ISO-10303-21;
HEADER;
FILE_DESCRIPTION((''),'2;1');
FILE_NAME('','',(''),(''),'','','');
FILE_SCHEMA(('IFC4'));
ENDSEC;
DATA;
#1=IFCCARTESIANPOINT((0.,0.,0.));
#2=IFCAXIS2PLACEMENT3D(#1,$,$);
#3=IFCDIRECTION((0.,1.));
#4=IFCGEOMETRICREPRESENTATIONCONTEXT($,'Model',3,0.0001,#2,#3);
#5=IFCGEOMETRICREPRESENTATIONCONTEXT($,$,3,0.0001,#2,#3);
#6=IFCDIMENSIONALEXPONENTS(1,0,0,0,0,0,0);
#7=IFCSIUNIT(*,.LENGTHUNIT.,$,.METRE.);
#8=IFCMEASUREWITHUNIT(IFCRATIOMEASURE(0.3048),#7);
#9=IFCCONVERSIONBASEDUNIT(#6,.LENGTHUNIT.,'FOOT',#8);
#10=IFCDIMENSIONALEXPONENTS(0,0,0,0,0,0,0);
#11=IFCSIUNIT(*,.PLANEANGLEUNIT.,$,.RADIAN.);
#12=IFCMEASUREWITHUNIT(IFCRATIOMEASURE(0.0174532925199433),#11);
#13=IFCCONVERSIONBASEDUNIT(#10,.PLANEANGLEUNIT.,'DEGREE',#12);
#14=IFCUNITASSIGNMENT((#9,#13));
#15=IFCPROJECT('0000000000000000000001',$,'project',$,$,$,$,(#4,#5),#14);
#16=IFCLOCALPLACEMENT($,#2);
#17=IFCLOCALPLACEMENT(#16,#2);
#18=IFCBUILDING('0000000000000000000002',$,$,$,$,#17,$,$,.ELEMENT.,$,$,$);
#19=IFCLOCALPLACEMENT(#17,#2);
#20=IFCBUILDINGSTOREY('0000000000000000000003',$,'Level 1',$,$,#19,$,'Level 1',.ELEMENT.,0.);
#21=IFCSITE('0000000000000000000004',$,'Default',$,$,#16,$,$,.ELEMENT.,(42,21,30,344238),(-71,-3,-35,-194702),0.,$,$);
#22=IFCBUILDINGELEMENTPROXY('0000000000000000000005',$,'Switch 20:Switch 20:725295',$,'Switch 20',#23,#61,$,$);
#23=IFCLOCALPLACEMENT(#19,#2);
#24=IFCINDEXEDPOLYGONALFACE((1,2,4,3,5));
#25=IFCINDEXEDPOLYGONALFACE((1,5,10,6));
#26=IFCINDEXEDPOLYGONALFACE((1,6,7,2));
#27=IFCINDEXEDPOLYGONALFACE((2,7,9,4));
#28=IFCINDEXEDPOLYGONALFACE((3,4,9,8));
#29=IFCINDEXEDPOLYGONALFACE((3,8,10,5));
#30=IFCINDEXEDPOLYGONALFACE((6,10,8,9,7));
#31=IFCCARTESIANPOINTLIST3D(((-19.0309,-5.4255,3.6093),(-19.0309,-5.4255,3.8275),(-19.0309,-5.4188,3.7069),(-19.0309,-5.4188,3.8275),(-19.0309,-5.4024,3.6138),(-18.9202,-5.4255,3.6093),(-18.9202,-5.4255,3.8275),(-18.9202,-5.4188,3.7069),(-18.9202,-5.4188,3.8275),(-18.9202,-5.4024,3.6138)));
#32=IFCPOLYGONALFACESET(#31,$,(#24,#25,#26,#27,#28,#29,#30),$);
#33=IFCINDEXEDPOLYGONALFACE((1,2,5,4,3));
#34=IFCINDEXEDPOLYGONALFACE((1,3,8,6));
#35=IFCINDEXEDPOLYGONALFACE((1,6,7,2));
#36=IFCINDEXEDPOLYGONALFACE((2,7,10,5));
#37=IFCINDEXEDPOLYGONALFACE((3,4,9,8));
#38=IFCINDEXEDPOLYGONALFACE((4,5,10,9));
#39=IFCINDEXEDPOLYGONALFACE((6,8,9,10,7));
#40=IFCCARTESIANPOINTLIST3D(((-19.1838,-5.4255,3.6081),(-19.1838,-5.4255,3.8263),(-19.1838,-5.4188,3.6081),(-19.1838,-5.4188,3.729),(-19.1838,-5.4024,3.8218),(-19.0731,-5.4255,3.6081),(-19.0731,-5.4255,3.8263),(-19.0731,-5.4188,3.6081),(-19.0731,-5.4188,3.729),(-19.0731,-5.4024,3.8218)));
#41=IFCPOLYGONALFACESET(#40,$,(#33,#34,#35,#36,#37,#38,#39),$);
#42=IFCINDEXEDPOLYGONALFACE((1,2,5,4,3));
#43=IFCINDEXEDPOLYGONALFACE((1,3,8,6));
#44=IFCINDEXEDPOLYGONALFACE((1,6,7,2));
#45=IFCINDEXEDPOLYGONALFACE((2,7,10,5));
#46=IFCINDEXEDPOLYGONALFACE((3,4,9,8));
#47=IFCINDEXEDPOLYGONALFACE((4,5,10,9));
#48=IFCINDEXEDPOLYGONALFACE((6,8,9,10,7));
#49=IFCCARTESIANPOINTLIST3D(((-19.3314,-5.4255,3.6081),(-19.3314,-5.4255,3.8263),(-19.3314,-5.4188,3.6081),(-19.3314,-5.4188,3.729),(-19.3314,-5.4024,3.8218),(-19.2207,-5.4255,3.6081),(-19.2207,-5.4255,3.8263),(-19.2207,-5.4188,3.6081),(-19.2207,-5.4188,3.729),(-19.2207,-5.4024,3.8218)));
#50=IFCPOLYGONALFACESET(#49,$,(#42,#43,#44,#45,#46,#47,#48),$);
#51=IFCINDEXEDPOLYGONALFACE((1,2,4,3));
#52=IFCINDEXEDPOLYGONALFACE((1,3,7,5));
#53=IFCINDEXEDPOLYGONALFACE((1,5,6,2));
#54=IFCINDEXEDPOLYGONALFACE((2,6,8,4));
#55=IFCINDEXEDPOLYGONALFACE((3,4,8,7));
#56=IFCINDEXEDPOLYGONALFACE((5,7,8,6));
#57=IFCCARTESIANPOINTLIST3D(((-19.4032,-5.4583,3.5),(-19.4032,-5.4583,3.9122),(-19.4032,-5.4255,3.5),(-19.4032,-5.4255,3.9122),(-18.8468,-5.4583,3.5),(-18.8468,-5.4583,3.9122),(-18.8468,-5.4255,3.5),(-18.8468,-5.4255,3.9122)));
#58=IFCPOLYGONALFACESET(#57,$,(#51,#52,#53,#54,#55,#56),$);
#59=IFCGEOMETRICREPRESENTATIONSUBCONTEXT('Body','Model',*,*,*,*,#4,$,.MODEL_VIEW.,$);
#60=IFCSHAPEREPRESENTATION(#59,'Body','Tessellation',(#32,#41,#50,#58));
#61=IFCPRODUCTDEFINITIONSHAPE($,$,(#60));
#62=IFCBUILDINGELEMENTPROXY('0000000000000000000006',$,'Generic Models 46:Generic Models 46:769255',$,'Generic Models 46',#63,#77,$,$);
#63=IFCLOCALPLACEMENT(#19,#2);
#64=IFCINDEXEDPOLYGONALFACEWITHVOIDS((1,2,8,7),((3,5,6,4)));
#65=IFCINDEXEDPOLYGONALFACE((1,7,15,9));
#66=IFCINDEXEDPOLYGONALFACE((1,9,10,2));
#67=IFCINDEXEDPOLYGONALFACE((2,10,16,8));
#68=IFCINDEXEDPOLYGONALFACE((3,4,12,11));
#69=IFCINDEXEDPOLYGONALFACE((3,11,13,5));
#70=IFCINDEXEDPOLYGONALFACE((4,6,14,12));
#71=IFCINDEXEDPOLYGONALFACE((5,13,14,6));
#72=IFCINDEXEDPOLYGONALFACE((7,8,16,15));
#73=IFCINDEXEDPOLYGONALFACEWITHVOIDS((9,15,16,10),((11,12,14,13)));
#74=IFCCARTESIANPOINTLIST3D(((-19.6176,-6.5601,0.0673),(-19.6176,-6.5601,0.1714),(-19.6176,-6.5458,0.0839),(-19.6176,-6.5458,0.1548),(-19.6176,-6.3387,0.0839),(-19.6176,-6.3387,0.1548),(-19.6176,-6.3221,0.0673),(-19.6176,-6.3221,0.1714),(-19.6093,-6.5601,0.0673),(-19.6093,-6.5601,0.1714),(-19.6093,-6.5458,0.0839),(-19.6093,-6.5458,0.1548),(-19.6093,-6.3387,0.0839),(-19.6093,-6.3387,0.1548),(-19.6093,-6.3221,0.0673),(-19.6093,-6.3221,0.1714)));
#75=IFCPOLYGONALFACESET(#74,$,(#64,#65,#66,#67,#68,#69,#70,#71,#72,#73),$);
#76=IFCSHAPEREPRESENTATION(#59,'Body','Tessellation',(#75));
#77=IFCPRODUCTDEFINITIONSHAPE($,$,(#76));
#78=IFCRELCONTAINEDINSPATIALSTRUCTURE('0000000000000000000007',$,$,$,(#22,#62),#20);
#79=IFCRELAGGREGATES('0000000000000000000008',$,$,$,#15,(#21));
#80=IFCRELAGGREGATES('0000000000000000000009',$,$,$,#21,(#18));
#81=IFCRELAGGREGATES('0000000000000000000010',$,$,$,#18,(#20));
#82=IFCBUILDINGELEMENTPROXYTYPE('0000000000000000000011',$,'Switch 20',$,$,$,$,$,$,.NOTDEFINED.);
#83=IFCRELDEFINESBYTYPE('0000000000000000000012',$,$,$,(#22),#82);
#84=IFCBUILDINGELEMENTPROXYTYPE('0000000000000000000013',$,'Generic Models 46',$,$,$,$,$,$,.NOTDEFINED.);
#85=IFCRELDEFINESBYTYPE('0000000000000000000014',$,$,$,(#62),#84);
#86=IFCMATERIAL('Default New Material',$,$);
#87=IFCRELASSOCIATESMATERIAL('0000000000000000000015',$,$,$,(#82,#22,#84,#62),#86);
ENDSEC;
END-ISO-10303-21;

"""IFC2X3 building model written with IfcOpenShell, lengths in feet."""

from ifc_helpers import new_model, entity, si_unit, converted_unit, direction, frame, frame_2d, origin, place, context, subcontext, project, spatial, polyline, rectangle, outline, extrude, source, transform, mapped, material, type_object, type_shapes, element, save


model = new_model("IFC2X3")

# Units and contexts
model_context = context("Model", 3, precision=0.0001, world=origin(), true_north=direction((0.0, 1.0)))
context_of_model = context(None, 3, precision=0.0001, world=origin(), true_north=direction((0.0, 1.0)))
body_context = subcontext(model_context, "Body", "Model", "MODEL_VIEW")
ifc_project = project(units=[converted_unit("LENGTHUNIT", "FOOT", entity("IfcRatioMeasure", 0.3048), si_unit("LENGTHUNIT", "METRE"), dimensions=[1, 0, 0, 0, 0, 0, 0]), converted_unit("PLANEANGLEUNIT", "DEGREE", entity("IfcRatioMeasure", 0.0174532925199433), si_unit("PLANEANGLEUNIT", "RADIAN"), dimensions=[0, 0, 0, 0, 0, 0, 0])], contexts=[model_context, context_of_model])

# Site, building, storey
site_placement = place(None, origin())
site = spatial("IfcSite", under=ifc_project, at=site_placement, Name="Default", CompositionType="ELEMENT", RefLatitude=(42, 21, 30, 344238), RefLongitude=(-71, -3, -35, -194702), RefElevation=0.0)
building_placement = place(site_placement, origin())
building = spatial("IfcBuilding", under=site, at=building_placement, CompositionType="ELEMENT")
storey_placement = place(building_placement, origin())
storey = spatial("IfcBuildingStorey", under=building, at=storey_placement, Name="Level 1", LongName="Level 1", CompositionType="ELEMENT", Elevation=0.0)

# Shared definitions
ifc_material_1 = material(Name="Default New Material")

# Building element proxies
building_element_proxy_type_1 = type_object("IfcBuildingElementProxyType", Name="Switch 20", PredefinedType="NOTDEFINED", material=ifc_material_1)
shared_shape_1 = source(origin(), body_context, "Body", "SweptSolid", [
    extrude(outline(polyline([(-0.0277, -0.1043), (-0.0042, -0.1043), (-0.0025, -0.0098), (0.0205, 0.1086), (0.0139, 0.1099), (-0.0277, -0.1043)])), frame((0.0941, 0.0402, 0.217), z_axis=(1.0, 0.0, 0.0), x_axis=(0.0, 0.981627, 0.190809)), (0.0, 0.0, 1.0), 0.1107),
    extrude(outline(polyline([(-0.1076, -0.0073), (0.1106, -0.0073), (0.1106, -0.0006), (-0.0103, -0.0006), (-0.1032, 0.0158), (-0.1076, -0.0073)])), frame((-0.0588, 0.0401, 0.2187), z_axis=(1.0, 0.0, 0.0), x_axis=(0.0, 0.0, -1.0)), (0.0, 0.0, 1.0), 0.1107),
    extrude(outline(polyline([(-0.1076, -0.0073), (0.1106, -0.0073), (0.1106, -0.0006), (-0.0103, -0.0006), (-0.1032, 0.0158), (-0.1076, -0.0073)])), frame((-0.2064, 0.0401, 0.2187), z_axis=(1.0, 0.0, 0.0), x_axis=(0.0, 0.0, -1.0)), (0.0, 0.0, 1.0), 0.1107),
    extrude(rectangle(XDim=0.0329, YDim=0.5563, at=frame_2d((0.0, 0.0), x_axis=(1.0, 0.0))), frame((0.0, 0.0164, 0.0), z_axis=(0.0, 0.0, 1.0), x_axis=(0.0, -1.0, 0.0)), (0.0, 0.0, 1.0), 0.4122),
])
type_shapes(building_element_proxy_type_1, [shared_shape_1])
proxy_1_placement = place(storey_placement, frame((-19.125, -5.4583, 3.5)))
element("IfcBuildingElementProxy", 1, at=proxy_1_placement, inside=storey, type_object=building_element_proxy_type_1, material=ifc_material_1, Name="Switch 20:Switch 20:725295", ObjectType="Switch 20", context=body_context, shape_type="MappedRepresentation", body=[
    mapped(shared_shape_1, transform((0.0, 0.0, 0.0), scale=1.0)),
])
building_element_proxy_type_2 = type_object("IfcBuildingElementProxyType", Name="Generic Models 46", PredefinedType="NOTDEFINED", material=ifc_material_1)
shared_shape_2 = source(origin(), body_context, "Body", "SweptSolid", [
    extrude(outline(polyline([(-0.0521, -0.119), (0.0521, -0.119), (0.0521, 0.119), (-0.0521, 0.119), (-0.0521, -0.119)]), holes=[polyline([(-0.0355, -0.1024), (-0.0355, 0.1047), (0.0355, 0.1047), (0.0355, -0.1024), (-0.0355, -0.1024)])]), frame((0.0, 0.119, 0.0521), z_axis=(1.0, 0.0, 0.0), x_axis=(0.0, 0.0, 1.0)), (0.0, 0.0, 1.0), 0.0083),
])
type_shapes(building_element_proxy_type_2, [shared_shape_2])
proxy_2_placement = place(storey_placement, frame((-19.6176, -6.5601, 0.0673)))
element("IfcBuildingElementProxy", 2, at=proxy_2_placement, inside=storey, type_object=building_element_proxy_type_2, material=ifc_material_1, Name="Generic Models 46:Generic Models 46:769255", ObjectType="Generic Models 46", context=body_context, shape_type="MappedRepresentation", body=[
    mapped(shared_shape_2, transform((0.0, 0.0, 0.0), scale=1.0)),
])

save(model, "model.ifc")
